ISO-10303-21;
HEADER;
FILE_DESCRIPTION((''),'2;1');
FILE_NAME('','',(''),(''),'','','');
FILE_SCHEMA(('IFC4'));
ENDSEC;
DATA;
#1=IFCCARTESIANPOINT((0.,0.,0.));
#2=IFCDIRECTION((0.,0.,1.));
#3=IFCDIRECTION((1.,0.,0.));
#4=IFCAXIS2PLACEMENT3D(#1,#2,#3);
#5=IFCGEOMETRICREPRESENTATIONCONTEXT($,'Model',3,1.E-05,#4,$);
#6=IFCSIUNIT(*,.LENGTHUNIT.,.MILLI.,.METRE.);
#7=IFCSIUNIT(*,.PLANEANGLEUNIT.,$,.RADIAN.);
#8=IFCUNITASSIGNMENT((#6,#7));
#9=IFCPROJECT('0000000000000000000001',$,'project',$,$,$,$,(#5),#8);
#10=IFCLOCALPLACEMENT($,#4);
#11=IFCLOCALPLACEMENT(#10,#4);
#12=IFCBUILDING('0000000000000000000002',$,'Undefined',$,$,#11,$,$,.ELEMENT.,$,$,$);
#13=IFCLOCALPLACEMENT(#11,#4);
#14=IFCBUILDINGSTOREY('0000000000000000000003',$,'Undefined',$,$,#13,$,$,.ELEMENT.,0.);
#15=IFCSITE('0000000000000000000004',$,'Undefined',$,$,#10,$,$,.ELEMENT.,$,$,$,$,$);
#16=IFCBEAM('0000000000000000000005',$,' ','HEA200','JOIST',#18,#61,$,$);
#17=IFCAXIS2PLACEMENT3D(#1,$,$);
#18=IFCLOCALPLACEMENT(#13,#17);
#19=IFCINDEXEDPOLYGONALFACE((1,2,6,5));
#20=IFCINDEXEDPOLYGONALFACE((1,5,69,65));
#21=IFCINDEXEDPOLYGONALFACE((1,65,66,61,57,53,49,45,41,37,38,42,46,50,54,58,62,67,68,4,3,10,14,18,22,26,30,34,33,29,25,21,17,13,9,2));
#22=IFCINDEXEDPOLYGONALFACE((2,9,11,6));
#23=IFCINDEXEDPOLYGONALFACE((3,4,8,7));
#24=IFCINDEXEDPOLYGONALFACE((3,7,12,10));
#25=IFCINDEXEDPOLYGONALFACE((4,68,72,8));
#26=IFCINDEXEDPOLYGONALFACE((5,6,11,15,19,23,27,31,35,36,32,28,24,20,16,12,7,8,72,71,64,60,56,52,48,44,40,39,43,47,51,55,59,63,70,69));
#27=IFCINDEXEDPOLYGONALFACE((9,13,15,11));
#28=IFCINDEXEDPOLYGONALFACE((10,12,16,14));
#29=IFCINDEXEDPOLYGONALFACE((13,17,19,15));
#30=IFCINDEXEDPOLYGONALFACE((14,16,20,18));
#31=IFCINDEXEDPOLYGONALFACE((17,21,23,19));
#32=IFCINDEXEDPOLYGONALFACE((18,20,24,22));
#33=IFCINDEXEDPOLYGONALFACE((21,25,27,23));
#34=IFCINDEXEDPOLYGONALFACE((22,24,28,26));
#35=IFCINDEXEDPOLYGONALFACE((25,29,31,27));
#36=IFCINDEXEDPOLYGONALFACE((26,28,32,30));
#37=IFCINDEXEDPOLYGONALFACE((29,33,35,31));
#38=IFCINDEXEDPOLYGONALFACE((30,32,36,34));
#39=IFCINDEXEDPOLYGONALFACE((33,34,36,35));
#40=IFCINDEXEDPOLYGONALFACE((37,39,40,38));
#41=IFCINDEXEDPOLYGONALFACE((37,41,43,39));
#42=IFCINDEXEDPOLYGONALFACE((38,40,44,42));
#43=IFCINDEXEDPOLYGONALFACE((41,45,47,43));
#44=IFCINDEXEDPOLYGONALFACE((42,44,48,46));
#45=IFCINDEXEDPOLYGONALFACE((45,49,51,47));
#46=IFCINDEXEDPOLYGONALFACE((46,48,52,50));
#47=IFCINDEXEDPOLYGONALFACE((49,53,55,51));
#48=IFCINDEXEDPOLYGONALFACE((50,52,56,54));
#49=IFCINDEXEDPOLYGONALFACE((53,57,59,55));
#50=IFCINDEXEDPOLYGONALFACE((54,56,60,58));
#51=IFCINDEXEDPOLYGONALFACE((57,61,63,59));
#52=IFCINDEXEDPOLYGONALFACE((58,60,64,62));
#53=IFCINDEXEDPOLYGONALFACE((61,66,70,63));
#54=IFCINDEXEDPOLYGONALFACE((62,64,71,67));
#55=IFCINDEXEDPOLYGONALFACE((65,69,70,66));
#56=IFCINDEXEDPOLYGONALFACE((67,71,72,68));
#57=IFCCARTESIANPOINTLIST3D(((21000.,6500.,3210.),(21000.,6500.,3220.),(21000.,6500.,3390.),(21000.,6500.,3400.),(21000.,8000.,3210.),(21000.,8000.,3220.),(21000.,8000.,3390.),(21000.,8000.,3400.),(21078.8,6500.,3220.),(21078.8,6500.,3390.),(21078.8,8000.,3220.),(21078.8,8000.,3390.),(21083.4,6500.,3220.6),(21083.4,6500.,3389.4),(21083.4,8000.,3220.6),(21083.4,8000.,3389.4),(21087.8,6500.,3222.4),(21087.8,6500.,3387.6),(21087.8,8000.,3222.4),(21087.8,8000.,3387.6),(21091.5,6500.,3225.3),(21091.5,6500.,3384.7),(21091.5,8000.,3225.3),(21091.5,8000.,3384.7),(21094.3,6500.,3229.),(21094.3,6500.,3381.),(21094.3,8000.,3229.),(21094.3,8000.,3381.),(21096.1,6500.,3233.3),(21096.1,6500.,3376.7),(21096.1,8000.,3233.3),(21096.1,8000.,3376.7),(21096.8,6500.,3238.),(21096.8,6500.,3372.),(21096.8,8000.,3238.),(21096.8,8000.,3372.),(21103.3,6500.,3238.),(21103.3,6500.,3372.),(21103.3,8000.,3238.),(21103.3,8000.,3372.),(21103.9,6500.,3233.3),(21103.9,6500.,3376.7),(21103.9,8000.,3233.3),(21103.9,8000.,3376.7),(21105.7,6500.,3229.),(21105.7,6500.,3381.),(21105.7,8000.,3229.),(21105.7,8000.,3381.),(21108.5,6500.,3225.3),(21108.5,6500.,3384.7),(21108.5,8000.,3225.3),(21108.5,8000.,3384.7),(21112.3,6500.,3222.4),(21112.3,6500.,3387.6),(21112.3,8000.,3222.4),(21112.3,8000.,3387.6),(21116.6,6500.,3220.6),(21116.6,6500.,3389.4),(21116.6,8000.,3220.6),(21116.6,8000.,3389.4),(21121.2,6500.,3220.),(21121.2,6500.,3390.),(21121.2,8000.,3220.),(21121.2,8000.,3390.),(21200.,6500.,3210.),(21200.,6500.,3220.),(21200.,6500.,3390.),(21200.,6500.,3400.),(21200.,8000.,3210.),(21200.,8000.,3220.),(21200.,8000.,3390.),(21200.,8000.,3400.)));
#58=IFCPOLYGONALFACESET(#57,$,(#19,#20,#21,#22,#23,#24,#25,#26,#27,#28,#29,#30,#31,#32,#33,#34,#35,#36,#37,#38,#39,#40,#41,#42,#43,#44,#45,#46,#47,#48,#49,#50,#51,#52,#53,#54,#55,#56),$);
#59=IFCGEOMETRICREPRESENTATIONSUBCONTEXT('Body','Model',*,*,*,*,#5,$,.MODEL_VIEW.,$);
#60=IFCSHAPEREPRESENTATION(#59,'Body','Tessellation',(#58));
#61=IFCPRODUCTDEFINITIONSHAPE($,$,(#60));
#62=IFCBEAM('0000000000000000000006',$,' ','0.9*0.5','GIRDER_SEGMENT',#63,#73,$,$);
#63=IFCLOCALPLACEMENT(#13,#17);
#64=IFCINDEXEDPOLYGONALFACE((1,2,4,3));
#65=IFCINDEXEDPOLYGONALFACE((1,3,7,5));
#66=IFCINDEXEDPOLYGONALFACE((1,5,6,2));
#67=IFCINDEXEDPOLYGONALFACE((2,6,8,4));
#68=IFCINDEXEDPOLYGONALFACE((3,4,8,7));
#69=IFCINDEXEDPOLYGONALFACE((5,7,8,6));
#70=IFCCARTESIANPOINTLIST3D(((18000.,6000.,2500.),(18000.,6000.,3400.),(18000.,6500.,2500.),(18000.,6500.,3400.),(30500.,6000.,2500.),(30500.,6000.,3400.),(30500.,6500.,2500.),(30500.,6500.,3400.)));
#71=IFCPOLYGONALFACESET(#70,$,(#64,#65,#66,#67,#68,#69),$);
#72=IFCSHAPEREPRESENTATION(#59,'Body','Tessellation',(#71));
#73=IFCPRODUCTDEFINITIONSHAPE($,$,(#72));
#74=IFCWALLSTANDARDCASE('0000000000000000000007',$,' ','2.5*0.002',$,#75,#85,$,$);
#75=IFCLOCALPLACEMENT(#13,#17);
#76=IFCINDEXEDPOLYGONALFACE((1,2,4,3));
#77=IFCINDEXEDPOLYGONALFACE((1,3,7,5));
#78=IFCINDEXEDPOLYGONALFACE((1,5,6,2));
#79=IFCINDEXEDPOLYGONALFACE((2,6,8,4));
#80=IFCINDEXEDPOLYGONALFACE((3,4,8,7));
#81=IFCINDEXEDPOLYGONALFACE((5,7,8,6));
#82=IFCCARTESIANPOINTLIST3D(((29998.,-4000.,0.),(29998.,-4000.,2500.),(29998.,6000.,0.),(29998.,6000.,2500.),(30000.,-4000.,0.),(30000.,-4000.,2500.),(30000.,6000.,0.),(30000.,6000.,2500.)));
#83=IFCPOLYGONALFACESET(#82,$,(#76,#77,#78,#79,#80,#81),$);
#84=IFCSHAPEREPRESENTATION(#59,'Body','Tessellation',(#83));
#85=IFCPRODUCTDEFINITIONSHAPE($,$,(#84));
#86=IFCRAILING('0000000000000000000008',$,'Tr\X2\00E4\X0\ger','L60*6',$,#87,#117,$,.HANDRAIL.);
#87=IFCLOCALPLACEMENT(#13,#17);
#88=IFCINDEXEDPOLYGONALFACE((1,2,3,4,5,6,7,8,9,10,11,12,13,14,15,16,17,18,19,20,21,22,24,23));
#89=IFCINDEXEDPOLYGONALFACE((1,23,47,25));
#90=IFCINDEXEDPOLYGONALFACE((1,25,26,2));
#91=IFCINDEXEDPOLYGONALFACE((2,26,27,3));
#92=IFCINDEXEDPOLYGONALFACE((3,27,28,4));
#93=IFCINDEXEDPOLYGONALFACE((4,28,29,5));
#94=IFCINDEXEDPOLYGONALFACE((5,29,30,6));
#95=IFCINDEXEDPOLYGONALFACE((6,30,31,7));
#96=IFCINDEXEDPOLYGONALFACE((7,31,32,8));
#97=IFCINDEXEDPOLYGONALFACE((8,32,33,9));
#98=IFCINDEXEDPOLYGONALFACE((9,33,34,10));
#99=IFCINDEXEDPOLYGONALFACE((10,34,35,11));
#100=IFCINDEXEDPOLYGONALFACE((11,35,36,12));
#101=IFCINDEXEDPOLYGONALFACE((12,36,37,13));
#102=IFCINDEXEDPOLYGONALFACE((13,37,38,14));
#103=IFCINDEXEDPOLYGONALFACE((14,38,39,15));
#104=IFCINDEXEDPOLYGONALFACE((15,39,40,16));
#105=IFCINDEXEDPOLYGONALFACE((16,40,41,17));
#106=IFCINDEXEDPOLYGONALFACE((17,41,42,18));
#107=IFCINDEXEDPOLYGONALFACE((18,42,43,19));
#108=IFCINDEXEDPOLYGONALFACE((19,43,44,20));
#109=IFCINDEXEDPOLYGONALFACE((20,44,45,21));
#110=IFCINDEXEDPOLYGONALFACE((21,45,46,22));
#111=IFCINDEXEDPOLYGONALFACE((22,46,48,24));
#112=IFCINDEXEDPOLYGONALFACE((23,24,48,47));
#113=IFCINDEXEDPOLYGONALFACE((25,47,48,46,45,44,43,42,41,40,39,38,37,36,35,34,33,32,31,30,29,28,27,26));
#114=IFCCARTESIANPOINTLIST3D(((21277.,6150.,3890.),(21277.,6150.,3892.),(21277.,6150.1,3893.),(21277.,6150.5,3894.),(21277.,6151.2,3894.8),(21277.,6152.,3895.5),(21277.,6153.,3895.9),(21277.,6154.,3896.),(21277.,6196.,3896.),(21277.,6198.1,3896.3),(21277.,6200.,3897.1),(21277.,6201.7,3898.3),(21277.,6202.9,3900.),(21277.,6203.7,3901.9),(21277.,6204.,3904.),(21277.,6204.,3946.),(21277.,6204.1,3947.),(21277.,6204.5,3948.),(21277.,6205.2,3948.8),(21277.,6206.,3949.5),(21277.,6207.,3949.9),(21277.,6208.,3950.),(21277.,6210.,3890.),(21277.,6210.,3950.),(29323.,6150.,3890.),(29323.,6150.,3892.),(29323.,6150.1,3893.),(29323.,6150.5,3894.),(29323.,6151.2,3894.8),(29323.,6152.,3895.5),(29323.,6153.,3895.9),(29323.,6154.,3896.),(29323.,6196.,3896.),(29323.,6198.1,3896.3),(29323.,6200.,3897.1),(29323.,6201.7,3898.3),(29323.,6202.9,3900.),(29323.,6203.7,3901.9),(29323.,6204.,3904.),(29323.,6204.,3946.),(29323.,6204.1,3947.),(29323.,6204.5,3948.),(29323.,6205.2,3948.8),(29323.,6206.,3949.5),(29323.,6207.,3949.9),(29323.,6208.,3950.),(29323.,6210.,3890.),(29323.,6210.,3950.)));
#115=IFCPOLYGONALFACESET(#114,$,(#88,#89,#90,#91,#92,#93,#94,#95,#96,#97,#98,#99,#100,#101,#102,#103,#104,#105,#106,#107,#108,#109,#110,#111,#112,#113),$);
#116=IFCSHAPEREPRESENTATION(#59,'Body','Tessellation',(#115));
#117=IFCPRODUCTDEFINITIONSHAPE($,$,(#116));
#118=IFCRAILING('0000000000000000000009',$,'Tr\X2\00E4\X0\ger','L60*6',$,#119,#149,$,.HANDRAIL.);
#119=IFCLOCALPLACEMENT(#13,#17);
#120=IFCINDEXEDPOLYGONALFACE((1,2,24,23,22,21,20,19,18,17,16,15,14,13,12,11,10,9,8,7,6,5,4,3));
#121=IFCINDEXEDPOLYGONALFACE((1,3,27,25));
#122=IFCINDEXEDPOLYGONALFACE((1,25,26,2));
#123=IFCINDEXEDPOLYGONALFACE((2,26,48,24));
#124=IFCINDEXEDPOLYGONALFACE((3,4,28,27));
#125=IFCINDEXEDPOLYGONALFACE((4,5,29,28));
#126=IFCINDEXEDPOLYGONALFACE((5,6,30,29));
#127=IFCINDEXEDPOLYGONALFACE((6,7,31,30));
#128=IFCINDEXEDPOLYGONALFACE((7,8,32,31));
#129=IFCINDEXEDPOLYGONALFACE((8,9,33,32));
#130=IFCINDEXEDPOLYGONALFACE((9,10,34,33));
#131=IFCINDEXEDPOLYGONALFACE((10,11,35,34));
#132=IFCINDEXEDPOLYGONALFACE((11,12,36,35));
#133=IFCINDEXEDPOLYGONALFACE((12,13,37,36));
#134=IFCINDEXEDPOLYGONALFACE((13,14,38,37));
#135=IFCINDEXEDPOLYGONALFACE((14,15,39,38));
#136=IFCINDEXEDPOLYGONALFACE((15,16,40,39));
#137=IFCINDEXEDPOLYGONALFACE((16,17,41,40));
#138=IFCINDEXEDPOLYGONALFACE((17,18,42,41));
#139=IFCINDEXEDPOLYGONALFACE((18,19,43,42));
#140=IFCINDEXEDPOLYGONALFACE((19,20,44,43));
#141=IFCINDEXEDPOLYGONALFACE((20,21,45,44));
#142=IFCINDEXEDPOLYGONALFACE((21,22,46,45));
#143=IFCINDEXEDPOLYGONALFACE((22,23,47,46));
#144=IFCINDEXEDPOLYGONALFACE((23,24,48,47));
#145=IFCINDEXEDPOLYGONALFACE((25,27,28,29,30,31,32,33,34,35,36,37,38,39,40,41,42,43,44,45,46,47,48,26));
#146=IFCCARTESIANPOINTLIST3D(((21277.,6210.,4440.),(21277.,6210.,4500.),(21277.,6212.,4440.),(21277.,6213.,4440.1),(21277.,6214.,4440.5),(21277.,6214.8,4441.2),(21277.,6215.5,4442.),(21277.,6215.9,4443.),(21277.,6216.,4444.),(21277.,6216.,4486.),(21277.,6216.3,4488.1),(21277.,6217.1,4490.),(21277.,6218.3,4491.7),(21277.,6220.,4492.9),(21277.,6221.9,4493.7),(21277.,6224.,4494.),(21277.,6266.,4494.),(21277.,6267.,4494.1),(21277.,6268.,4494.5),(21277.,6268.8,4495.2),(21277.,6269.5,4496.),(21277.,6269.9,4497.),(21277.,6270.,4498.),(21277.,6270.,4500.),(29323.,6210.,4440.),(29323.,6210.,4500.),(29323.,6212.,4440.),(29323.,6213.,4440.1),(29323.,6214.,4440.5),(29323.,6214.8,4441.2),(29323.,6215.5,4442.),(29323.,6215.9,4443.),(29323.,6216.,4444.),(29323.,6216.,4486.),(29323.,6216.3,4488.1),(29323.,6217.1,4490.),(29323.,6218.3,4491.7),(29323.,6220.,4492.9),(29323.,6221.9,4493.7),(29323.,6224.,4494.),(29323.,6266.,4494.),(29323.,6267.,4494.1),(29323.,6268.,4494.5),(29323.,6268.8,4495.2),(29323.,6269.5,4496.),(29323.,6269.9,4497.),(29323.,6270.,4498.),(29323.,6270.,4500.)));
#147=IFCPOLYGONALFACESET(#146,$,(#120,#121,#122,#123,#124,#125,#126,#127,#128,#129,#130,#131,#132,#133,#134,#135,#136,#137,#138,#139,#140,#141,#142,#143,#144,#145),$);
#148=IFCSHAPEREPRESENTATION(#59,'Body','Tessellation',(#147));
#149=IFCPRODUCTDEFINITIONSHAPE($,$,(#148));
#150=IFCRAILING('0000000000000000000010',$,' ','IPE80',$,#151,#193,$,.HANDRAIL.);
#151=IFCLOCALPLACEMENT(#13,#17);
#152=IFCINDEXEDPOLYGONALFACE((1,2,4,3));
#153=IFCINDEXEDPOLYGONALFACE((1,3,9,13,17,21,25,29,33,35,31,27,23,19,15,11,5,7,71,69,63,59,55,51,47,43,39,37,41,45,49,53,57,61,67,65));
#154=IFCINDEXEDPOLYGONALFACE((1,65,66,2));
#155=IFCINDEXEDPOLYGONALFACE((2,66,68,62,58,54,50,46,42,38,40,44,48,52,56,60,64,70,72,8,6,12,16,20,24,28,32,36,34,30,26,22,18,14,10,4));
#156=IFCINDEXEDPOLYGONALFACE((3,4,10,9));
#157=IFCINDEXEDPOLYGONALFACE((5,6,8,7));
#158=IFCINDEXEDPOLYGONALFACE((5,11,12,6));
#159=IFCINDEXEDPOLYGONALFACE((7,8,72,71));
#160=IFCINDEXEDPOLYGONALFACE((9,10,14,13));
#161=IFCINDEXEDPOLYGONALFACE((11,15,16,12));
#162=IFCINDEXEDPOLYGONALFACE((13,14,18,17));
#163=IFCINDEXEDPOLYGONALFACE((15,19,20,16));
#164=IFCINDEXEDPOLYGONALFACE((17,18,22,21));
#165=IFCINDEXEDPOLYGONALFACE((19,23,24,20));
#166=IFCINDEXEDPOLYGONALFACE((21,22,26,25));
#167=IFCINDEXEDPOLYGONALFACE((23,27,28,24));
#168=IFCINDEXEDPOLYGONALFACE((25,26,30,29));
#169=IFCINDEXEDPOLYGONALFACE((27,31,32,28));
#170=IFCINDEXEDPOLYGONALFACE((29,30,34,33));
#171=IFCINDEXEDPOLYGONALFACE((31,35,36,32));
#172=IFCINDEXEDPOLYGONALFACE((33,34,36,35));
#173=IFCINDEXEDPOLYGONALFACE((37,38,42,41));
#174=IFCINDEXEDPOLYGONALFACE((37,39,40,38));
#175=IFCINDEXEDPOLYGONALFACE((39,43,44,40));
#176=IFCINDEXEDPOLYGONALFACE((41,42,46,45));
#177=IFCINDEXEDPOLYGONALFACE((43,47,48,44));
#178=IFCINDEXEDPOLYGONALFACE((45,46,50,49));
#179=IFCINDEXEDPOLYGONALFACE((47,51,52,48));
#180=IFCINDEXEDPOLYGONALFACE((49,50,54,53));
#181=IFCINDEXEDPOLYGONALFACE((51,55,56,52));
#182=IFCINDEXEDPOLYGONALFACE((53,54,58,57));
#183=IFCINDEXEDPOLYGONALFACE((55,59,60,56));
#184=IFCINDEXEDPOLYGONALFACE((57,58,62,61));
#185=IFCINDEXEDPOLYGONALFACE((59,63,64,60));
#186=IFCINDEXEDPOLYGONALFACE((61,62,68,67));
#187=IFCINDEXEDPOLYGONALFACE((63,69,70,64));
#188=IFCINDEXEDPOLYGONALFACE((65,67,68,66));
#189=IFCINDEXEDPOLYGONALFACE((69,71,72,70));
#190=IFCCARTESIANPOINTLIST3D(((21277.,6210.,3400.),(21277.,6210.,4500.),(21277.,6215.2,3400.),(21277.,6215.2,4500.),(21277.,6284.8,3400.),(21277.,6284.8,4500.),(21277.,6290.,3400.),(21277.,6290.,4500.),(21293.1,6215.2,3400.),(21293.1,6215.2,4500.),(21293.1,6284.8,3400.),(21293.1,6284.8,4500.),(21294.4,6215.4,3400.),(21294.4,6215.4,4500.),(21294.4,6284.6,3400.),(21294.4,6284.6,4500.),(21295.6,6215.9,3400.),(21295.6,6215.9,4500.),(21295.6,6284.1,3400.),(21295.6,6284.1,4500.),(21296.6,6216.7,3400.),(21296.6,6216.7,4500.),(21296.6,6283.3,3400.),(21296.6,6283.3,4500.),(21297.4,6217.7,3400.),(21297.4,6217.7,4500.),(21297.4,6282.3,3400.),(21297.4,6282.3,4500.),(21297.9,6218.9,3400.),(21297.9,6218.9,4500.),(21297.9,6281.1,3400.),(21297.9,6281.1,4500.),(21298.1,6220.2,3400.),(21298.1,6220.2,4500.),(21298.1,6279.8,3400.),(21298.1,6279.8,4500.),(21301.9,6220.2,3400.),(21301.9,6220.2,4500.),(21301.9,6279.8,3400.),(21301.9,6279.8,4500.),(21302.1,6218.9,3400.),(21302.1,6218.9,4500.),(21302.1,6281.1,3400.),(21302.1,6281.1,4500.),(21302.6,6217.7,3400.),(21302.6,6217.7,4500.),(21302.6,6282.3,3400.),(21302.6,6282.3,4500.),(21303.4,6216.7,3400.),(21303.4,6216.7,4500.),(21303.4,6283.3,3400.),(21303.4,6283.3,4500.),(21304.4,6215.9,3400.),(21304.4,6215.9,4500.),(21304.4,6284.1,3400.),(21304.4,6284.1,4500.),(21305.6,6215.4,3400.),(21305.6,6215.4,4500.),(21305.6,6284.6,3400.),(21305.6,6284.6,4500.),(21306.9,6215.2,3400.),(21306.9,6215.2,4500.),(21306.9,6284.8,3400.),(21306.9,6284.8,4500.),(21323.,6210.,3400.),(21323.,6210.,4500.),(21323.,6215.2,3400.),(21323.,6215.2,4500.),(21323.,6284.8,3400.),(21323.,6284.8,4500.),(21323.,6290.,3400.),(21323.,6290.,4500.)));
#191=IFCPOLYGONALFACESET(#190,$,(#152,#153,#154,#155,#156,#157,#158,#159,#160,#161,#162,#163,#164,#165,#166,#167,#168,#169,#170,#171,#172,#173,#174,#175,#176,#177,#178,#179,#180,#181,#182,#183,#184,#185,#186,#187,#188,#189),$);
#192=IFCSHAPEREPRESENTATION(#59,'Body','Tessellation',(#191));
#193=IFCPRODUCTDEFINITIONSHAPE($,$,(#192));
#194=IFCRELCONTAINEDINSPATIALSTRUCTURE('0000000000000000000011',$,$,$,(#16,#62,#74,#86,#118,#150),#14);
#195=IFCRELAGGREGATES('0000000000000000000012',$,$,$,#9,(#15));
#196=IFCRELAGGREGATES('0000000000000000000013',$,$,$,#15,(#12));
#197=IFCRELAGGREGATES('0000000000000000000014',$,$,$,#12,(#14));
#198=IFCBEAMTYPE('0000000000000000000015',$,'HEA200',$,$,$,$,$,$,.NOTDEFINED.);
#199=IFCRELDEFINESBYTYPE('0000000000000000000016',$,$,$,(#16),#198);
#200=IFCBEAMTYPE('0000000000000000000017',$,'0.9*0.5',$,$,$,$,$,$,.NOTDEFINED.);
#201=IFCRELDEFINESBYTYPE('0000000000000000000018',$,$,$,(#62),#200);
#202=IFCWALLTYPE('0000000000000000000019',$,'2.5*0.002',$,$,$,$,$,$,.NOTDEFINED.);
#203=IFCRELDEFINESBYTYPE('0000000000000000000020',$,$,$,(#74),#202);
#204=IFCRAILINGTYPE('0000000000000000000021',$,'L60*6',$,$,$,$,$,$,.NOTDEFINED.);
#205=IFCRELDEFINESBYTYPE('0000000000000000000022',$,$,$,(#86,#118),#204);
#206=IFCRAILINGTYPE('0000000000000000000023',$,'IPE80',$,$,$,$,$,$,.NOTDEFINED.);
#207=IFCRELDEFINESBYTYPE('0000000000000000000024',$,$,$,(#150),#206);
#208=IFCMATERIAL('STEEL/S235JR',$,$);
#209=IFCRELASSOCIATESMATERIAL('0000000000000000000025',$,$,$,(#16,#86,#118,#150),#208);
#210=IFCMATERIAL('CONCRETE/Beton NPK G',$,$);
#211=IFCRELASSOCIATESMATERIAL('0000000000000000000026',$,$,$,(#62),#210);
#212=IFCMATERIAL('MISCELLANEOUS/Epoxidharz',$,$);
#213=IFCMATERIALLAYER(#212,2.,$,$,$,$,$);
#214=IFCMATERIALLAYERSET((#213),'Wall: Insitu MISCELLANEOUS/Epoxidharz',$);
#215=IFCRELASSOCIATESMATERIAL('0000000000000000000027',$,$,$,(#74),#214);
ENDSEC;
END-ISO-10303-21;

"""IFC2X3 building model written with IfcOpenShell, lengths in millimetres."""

from ifc_helpers import new_model, si_unit, frame, frame_2d, origin_with_axes, origin_2d_with_axis, place, context, subcontext, project, spatial, rectangle, i_section, l_section, extrude, material, layer, layer_set, layer_usage, type_object, element, save


model = new_model("IFC2X3")

# Units and contexts
model_context = context("Model", 3, precision=1e-05, world=origin_with_axes())
body_context = subcontext(model_context, "Body", "Model", "MODEL_VIEW")
ifc_project = project(units=[si_unit("LENGTHUNIT", "METRE", prefix="MILLI"), si_unit("PLANEANGLEUNIT", "RADIAN")], contexts=[model_context])

# Site, building, storey
site_placement = place(None, origin_with_axes())
site = spatial("IfcSite", under=ifc_project, at=site_placement, Name="Undefined", CompositionType="ELEMENT")
building_placement = place(site_placement, origin_with_axes())
building = spatial("IfcBuilding", under=site, at=building_placement, Name="Undefined", CompositionType="ELEMENT")
storey_placement = place(building_placement, origin_with_axes())
storey = spatial("IfcBuildingStorey", under=building, at=storey_placement, Name="Undefined", CompositionType="ELEMENT", Elevation=0.0)

# Shared definitions
ifc_material_1 = material(Name="CONCRETE/Beton NPK G")

# Beams
ifc_material_2 = material(Name="STEEL/S235JR")
beam_type_1 = type_object("IfcBeamType", Name="HEA200", PredefinedType="NOTDEFINED")
beam_1_placement = place(storey_placement, frame((21100.0, 6500.0, 3305.0), z_axis=(0.0, 0.0, 1.0), x_axis=(0.0, 1.0, 0.0)))
element("IfcBeam", 1, at=beam_1_placement, inside=storey, type_object=beam_type_1, material=ifc_material_2, Name=" ", Description="HEA200", ObjectType="JOIST", context=body_context, shape_type="SweptSolid", body=[
    extrude(i_section(OverallWidth=200.0, OverallDepth=190.0, WebThickness=6.5, FlangeThickness=10.0, FilletRadius=18.0, at=origin_2d_with_axis()), frame((1500.0, 0.0, 0.0), z_axis=(-1.0, 0.0, 0.0), x_axis=(0.0, -1.0, 0.0)), (0.0, 0.0, 1.0), 1500.0),
])
beam_type_2 = type_object("IfcBeamType", Name="0.9*0.5", PredefinedType="NOTDEFINED")
beam_2_placement = place(storey_placement, frame((30500.0, 6250.0, 2950.0), z_axis=(0.0, 0.0, 1.0), x_axis=(-1.0, 0.0, 0.0)))
element("IfcBeam", 2, at=beam_2_placement, inside=storey, type_object=beam_type_2, material=ifc_material_1, Name=" ", Description="0.9*0.5", ObjectType="GIRDER_SEGMENT", context=body_context, shape_type="SweptSolid", body=[
    extrude(rectangle(XDim=500.0, YDim=900.0, at=origin_2d_with_axis()), frame((12500.0, 0.0, 0.0), z_axis=(-1.0, 0.0, 0.0), x_axis=(0.0, -1.0, 0.0)), (0.0, 0.0, 1.0), 12500.0),
])

# Wall
ifc_material_3 = material(Name="MISCELLANEOUS/Epoxidharz")
ifc_layer = layer(ifc_material_3, 2.0)
ifc_layer_set = layer_set([ifc_layer], Name="Wall: Insitu MISCELLANEOUS/Epoxidharz")
ifc_layer_usage = layer_usage(ifc_layer_set, "AXIS2", "POSITIVE", -1.0)
wall_type = type_object("IfcWallType", Name="2.5*0.002", PredefinedType="NOTDEFINED")
wall_placement = place(storey_placement, frame((29999.0, 6000.0, 0.0), z_axis=(0.0, 0.0, 1.0), x_axis=(0.0, -1.0, 0.0)))
element("IfcWallStandardCase", 3, at=wall_placement, inside=storey, type_object=wall_type, material=ifc_layer_usage, Name=" ", Description="2.5*0.002", context=body_context, shape_type="SweptSolid", body=[
    extrude(rectangle(XDim=10000.0, YDim=2.0, at=frame_2d((0.0, 5000.0), x_axis=(0.0, -1.0))), frame((0.0, 0.0, 0.0), z_axis=(0.0, 0.0, 1.0), x_axis=(0.0, -1.0, 0.0)), (0.0, 0.0, 1.0), 2500.0),
])

# Railings
railing_type_1 = type_object("IfcRailingType", Name="L60*6", PredefinedType="NOTDEFINED")
for number, where, z_axis, x_axis, name in (
    (4, (21277.0, 6180.0, 3920.0), (0.0, 0.0, 1.0), (1.0, 0.0, 0.0), "Träger"),
    (5, (29323.0, 6240.0, 4470.0), (0.0, 1.0, 0.0), (-1.0, 0.0, 0.0), "Träger"),
):
    element("IfcRailing", number, at=place(storey_placement, frame(where, z_axis=z_axis, x_axis=x_axis)), inside=storey, type_object=railing_type_1, material=ifc_material_2, Name=name, Description="L60*6", PredefinedType="HANDRAIL", context=body_context, shape_type="SweptSolid", body=[
        extrude(l_section(Depth=60.0, Width=60.0, Thickness=6.0, FilletRadius=8.0, EdgeRadius=4.0, at=origin_2d_with_axis()), frame((8046.0, 0.0, 0.0), z_axis=(-1.0, 0.0, 0.0), x_axis=(0.0, -1.0, 0.0)), (0.0, 0.0, 1.0), 8046.0),
    ])
railing_type_2 = type_object("IfcRailingType", Name="IPE80", PredefinedType="NOTDEFINED")
for number, where, z_axis, x_axis, name in (
    (6, (21300.0, 6250.0, 3400.0), (0.0, 1.0, 0.0), (0.0, 0.0, 1.0), " "),
):
    element("IfcRailing", number, at=place(storey_placement, frame(where, z_axis=z_axis, x_axis=x_axis)), inside=storey, type_object=railing_type_2, material=ifc_material_2, Name=name, Description="IPE80", PredefinedType="HANDRAIL", context=body_context, shape_type="SweptSolid", body=[
        extrude(i_section(OverallWidth=46.0, OverallDepth=80.0, WebThickness=3.8, FlangeThickness=5.2, FilletRadius=5.0, at=origin_2d_with_axis()), frame((1100.0, 0.0, 0.0), z_axis=(-1.0, 0.0, 0.0), x_axis=(0.0, -1.0, 0.0)), (0.0, 0.0, 1.0), 1100.0),
    ])

save(model, "model.ifc")
